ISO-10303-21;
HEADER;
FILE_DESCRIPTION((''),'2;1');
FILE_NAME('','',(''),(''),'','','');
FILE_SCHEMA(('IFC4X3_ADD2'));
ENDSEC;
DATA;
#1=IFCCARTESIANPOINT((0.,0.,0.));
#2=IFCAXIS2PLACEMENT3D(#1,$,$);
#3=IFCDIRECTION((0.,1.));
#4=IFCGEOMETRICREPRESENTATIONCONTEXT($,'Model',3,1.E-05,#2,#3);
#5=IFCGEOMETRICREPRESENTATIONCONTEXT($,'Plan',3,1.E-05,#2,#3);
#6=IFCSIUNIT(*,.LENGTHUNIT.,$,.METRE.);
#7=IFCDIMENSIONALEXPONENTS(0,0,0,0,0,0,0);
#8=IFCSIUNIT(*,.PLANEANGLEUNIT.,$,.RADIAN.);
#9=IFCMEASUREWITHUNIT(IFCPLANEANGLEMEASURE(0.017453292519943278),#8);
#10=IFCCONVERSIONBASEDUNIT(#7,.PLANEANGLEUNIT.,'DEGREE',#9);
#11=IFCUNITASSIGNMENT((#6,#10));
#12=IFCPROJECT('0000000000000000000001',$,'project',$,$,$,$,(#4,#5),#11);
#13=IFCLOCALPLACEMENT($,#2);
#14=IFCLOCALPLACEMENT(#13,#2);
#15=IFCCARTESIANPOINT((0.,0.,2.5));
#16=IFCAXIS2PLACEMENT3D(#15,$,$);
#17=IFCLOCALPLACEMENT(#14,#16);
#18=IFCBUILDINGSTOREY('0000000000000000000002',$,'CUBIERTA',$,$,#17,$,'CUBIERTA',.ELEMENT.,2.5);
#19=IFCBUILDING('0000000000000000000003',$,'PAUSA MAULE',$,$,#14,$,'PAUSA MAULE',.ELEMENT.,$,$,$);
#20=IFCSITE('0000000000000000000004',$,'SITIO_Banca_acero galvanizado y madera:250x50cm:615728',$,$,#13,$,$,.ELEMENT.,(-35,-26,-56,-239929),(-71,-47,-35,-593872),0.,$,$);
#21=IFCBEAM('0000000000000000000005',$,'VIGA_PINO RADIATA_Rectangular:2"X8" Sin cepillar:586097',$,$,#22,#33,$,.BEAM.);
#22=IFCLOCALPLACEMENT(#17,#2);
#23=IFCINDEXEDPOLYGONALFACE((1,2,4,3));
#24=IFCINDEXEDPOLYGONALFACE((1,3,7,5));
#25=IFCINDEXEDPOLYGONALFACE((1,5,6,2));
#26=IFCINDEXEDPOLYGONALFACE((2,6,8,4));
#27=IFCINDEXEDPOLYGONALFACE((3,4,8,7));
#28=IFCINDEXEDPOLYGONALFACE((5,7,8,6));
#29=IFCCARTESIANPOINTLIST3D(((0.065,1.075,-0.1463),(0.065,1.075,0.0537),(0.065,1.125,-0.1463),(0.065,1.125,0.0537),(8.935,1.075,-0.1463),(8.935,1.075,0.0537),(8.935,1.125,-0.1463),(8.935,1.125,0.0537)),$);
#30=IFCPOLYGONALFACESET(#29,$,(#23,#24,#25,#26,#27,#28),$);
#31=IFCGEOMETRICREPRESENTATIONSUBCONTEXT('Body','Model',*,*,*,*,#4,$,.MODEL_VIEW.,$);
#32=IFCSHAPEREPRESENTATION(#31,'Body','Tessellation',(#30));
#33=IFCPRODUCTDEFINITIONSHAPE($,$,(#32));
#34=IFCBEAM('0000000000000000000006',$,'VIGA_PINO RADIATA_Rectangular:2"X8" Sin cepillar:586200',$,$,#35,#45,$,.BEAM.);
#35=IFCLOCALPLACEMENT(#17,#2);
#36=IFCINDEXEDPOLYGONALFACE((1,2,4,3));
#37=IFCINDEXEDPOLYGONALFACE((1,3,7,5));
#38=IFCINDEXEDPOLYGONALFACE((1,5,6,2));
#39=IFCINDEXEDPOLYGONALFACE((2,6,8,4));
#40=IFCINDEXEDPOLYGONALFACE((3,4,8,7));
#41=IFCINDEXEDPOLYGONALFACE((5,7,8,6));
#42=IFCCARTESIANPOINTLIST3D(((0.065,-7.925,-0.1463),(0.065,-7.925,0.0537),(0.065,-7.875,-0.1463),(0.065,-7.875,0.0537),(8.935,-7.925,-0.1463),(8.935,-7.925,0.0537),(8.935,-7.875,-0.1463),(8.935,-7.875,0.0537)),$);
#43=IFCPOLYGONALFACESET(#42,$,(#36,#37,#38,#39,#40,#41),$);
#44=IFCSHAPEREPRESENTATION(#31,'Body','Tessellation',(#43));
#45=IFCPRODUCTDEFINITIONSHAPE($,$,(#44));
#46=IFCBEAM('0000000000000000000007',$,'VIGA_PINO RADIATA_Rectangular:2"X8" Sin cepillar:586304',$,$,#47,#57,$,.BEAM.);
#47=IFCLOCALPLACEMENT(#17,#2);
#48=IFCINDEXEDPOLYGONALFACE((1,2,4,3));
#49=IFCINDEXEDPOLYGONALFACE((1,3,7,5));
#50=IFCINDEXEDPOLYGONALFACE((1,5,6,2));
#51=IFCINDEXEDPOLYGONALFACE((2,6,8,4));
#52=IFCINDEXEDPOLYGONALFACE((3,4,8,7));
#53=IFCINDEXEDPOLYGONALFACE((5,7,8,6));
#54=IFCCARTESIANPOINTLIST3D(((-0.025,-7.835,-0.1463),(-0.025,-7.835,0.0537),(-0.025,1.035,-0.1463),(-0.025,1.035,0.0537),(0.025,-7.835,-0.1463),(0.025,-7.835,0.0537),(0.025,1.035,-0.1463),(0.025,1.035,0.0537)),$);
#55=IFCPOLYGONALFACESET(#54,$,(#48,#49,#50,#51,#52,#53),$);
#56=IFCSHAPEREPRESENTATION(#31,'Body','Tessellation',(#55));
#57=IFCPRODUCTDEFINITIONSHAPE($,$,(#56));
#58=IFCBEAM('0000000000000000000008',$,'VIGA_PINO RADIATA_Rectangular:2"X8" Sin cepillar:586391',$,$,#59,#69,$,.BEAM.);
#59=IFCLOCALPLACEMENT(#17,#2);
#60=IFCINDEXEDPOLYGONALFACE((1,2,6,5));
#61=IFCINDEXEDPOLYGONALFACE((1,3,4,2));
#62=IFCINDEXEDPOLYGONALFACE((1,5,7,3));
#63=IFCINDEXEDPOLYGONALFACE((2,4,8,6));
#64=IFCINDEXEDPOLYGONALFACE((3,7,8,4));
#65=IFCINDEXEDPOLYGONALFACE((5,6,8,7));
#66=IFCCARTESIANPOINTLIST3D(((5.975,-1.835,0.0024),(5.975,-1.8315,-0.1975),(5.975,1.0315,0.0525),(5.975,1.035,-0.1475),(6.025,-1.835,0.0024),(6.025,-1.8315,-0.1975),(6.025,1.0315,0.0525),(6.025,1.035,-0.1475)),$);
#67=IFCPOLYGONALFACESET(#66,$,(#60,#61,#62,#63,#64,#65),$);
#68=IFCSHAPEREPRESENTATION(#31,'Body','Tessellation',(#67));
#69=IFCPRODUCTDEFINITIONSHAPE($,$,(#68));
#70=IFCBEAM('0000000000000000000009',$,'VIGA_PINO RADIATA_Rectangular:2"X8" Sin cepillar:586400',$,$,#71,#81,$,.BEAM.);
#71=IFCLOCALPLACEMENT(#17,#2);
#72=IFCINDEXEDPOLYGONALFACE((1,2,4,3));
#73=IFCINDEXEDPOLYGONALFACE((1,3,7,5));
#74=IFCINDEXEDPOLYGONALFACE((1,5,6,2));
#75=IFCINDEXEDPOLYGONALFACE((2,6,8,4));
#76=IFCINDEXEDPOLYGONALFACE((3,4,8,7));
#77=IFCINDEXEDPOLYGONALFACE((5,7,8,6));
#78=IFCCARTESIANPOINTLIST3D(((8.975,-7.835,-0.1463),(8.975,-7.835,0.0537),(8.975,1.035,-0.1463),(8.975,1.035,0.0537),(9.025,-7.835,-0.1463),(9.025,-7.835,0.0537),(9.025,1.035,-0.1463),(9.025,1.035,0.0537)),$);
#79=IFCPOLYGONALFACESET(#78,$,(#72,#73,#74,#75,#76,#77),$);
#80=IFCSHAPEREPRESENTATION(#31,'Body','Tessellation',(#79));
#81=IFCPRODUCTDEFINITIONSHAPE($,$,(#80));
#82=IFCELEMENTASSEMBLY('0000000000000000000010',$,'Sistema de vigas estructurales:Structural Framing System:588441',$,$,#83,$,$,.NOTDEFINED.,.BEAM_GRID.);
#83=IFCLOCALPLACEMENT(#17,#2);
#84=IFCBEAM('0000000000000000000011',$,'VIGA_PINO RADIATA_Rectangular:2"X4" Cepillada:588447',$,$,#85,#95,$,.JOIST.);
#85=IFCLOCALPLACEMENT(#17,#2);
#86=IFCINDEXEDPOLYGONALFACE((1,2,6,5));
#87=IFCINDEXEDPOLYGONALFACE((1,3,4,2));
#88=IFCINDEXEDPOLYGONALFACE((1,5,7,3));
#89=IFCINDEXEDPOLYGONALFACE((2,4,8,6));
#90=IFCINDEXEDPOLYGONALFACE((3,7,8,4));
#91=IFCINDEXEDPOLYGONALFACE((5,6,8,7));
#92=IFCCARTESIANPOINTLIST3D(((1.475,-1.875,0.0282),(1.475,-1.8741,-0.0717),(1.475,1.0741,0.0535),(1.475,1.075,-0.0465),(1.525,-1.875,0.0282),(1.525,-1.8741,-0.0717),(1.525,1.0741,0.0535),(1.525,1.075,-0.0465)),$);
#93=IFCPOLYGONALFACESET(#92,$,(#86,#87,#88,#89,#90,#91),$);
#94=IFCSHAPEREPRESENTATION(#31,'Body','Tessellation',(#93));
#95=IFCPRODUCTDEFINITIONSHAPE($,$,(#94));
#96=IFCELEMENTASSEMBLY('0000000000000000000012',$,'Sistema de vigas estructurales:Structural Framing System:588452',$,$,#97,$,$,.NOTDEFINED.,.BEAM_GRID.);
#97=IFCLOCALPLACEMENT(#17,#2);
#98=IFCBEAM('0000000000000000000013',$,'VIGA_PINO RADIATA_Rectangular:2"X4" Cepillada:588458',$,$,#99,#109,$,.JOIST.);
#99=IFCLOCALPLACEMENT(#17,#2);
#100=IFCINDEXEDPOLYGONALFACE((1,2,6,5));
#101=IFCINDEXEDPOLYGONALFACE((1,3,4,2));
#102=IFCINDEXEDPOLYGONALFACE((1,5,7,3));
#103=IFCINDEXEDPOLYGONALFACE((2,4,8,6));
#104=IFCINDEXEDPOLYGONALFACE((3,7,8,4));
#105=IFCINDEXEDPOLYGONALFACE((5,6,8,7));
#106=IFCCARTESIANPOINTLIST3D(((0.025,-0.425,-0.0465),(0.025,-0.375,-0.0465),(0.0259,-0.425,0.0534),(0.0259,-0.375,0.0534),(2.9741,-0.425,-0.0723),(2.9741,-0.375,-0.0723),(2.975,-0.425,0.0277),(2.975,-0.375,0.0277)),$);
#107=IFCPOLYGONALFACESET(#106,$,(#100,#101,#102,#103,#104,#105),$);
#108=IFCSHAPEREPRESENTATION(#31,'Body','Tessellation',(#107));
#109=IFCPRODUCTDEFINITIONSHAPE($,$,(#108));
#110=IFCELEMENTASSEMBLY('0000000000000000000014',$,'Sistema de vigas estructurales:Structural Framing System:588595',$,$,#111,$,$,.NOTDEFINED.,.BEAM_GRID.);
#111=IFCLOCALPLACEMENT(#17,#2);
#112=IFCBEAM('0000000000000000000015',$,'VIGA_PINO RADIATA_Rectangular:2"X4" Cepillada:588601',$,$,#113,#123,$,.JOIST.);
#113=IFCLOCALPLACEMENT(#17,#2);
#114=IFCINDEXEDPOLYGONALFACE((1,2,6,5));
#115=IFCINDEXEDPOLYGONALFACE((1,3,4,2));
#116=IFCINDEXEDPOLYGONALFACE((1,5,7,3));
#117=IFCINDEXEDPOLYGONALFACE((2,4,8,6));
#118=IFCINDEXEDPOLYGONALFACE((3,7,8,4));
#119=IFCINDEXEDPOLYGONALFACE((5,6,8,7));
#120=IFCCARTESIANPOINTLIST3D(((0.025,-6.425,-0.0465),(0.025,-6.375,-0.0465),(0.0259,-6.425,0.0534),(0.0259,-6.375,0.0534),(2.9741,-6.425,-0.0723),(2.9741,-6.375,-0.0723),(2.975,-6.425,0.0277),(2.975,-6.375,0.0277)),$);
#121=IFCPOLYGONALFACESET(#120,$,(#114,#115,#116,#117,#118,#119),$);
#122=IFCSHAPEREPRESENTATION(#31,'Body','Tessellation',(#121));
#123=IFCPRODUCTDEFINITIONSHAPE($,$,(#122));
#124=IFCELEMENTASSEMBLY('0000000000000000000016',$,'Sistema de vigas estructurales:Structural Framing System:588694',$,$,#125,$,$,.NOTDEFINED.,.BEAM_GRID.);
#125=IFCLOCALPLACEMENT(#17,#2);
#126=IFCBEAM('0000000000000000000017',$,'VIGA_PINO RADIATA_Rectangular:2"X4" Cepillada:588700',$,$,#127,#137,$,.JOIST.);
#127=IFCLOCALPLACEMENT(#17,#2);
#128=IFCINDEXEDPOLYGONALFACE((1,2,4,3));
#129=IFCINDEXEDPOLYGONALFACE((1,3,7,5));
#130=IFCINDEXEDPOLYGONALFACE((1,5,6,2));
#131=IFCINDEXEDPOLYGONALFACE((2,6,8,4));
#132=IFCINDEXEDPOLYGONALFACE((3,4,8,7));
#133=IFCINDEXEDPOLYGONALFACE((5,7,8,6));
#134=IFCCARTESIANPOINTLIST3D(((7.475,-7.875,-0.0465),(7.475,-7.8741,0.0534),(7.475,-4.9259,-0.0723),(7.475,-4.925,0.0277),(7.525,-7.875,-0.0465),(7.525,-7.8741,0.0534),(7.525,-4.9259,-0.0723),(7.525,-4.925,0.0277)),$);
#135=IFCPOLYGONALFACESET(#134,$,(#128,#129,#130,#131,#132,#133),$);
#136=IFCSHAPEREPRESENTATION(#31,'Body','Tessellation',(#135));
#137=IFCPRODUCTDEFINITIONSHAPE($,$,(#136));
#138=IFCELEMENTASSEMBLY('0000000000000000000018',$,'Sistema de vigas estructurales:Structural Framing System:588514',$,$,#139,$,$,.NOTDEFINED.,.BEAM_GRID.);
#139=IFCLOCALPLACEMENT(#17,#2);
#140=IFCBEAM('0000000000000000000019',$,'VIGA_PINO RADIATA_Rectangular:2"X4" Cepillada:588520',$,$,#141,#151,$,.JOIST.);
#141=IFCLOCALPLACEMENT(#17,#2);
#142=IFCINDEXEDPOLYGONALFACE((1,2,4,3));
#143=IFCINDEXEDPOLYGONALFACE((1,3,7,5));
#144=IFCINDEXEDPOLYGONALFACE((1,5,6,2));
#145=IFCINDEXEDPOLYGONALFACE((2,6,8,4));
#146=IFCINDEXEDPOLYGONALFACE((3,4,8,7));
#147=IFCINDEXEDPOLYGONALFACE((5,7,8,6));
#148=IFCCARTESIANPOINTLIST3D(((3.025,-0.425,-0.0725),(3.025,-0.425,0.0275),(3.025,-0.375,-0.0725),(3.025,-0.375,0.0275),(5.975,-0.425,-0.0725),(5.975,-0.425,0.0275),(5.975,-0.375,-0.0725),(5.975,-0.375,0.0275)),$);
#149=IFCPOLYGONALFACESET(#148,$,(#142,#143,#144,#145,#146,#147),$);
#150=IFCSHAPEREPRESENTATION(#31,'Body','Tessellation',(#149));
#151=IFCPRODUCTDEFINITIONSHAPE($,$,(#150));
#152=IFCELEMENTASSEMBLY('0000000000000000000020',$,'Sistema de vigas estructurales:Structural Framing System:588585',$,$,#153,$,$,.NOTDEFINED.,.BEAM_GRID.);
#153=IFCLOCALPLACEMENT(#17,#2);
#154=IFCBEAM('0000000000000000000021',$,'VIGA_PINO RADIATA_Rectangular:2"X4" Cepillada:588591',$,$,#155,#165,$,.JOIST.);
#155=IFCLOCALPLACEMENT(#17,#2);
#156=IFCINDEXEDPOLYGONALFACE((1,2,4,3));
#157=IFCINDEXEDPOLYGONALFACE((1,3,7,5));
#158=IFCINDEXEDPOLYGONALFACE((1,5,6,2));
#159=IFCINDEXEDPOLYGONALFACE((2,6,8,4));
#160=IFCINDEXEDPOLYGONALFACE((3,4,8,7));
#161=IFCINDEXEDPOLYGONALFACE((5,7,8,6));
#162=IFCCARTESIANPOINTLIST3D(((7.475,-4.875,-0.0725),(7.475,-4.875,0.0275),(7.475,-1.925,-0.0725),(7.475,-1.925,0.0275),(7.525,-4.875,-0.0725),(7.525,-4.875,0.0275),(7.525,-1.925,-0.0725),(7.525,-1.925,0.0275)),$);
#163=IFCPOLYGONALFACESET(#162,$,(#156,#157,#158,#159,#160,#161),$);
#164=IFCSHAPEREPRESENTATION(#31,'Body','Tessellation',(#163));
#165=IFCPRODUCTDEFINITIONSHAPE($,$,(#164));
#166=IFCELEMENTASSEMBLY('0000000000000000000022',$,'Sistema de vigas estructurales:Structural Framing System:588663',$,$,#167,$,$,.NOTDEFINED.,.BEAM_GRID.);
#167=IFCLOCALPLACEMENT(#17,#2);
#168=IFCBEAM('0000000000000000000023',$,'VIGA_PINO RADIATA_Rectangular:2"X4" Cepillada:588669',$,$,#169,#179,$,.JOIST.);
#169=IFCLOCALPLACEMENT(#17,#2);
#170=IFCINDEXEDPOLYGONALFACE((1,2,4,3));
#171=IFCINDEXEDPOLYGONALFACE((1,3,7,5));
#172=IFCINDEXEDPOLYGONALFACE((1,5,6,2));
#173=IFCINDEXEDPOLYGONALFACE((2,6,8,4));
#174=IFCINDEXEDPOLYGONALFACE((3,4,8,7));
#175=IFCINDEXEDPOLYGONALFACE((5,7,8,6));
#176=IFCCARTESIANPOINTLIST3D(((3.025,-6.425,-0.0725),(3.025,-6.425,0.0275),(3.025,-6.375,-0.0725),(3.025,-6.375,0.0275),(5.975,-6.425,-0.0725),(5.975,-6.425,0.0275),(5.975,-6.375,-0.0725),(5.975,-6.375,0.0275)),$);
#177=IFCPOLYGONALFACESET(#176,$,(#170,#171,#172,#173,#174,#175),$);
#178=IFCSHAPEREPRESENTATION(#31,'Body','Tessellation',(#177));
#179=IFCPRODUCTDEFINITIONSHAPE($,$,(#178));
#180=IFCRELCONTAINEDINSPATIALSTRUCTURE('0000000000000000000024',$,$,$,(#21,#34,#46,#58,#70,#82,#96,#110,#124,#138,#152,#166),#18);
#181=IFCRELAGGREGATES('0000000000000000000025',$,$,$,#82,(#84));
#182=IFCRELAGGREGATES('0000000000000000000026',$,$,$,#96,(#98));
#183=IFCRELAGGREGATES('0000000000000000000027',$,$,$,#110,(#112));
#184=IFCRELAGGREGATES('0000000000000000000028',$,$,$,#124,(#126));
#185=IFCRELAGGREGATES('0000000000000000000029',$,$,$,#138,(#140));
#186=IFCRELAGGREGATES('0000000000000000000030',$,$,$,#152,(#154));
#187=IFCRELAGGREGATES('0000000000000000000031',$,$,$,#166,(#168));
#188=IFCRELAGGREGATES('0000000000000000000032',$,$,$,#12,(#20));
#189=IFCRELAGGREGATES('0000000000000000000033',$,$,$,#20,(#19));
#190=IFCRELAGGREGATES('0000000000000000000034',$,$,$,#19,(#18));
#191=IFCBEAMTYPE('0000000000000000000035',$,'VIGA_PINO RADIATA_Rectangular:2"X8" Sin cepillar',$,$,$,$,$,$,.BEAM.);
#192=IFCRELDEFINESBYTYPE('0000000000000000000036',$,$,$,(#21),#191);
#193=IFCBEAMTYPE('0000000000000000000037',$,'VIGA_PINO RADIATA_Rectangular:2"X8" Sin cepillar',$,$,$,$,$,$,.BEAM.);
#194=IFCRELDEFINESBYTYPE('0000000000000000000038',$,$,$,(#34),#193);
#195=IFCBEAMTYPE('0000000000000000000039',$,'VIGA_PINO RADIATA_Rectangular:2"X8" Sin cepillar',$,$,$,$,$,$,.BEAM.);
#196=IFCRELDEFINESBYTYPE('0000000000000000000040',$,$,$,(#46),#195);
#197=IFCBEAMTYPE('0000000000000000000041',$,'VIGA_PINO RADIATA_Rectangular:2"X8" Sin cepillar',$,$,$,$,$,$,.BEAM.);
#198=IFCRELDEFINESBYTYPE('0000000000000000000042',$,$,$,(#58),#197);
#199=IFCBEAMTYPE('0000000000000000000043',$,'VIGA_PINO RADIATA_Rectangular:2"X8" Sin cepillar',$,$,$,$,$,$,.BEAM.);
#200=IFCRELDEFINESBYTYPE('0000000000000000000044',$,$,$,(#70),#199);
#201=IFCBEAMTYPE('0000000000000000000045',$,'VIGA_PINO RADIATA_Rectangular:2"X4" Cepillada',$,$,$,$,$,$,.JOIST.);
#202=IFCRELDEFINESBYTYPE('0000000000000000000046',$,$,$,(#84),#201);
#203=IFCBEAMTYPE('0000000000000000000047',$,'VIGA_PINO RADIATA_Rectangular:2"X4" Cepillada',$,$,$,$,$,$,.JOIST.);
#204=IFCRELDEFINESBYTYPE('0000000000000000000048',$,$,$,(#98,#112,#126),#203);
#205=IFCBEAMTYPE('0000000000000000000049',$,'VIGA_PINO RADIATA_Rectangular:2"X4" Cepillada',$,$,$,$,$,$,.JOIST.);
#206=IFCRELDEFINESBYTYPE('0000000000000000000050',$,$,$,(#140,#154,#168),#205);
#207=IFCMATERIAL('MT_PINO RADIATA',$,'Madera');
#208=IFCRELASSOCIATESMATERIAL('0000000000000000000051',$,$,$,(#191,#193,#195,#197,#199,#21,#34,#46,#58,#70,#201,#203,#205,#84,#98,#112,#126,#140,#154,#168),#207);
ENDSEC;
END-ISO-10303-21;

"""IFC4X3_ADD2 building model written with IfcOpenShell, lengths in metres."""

from ifc_helpers import new_model, entity, si_unit, converted_unit, direction, frame, origin, origin_2d_with_axis, place, context, subcontext, project, spatial, rectangle, extrude, source, transform, mapped, material, material_profile, profile_set, profile_usage, type_object, type_shapes, element, aggregate, save


model = new_model("IFC4X3_ADD2")

# Units and contexts
model_context = context("Model", 3, precision=1e-05, world=origin(), true_north=direction((0.0, 1.0)))
plan_context = context("Plan", 3, precision=1e-05, world=origin(), true_north=direction((0.0, 1.0)))
body_context = subcontext(model_context, "Body", "Model", "MODEL_VIEW")
ifc_project = project(units=[si_unit("LENGTHUNIT", "METRE"), converted_unit("PLANEANGLEUNIT", "DEGREE", entity("IfcPlaneAngleMeasure", 0.017453292519943278), si_unit("PLANEANGLEUNIT", "RADIAN"), dimensions=[0, 0, 0, 0, 0, 0, 0])], contexts=[model_context, plan_context])

# Site, building, storey
site_placement = place(None, origin())
site = spatial("IfcSite", under=ifc_project, at=site_placement, Name="SITIO_Banca_acero galvanizado y madera:250x50cm:615728", CompositionType="ELEMENT", RefLatitude=(-35, -26, -56, -239929), RefLongitude=(-71, -47, -35, -593872), RefElevation=0.0)
building_placement = place(site_placement, origin())
building = spatial("IfcBuilding", under=site, at=building_placement, Name="PAUSA MAULE", LongName="PAUSA MAULE", CompositionType="ELEMENT")
storey_placement = place(building_placement, frame((0.0, 0.0, 2.5)))
storey = spatial("IfcBuildingStorey", under=building, at=storey_placement, Name="CUBIERTA", LongName="CUBIERTA", CompositionType="ELEMENT", Elevation=2.5)

# Beams
ifc_material_1 = material(Name="MT_PINO RADIATA", Category="Madera")
ifc_material_profile_1 = material_profile(ifc_material_1, rectangle(XDim=8.87, YDim=0.05, at=origin_2d_with_axis()), Name="2\"X8\" Sin cepillar")
ifc_profile_set_1 = profile_set([ifc_material_profile_1], Name="2\"X8\" Sin cepillar")
ifc_profile_usage_1 = profile_usage(ifc_profile_set_1, cardinal=8)
beam_type_1 = type_object("IfcBeamType", Name="VIGA_PINO RADIATA_Rectangular:2\"X8\" Sin cepillar", PredefinedType="BEAM", material=ifc_profile_set_1)
shared_shape_1 = source(origin(), body_context, "Body", "SweptSolid", [
    extrude(rectangle(XDim=8.87, YDim=0.05, at=origin_2d_with_axis()), frame((0.0, 0.0, -0.1), z_axis=(0.0, 0.0, 1.0), x_axis=(-1.0, 0.0, 0.0)), (0.0, 0.0, 1.0), 0.2),
])
type_shapes(beam_type_1, [shared_shape_1])
beam_1_placement = place(storey_placement, frame((4.5, 1.1, -0.0463)))
element("IfcBeam", 1, at=beam_1_placement, inside=storey, type_object=beam_type_1, material=ifc_profile_usage_1, Name="VIGA_PINO RADIATA_Rectangular:2\"X8\" Sin cepillar:586097", PredefinedType="BEAM", context=body_context, shape_type="MappedRepresentation", body=[
    mapped(shared_shape_1, transform((0.0, 0.0, 0.0), scale=1.0)),
])
beam_type_2 = type_object("IfcBeamType", Name="VIGA_PINO RADIATA_Rectangular:2\"X8\" Sin cepillar", PredefinedType="BEAM", material=ifc_profile_set_1)
shared_shape_2 = source(origin(), body_context, "Body", "SweptSolid", [
    extrude(rectangle(XDim=8.87, YDim=0.05, at=origin_2d_with_axis()), frame((-0.01, 0.0, -0.1), z_axis=(0.0, 0.0, 1.0), x_axis=(-1.0, 0.0, 0.0)), (0.0, 0.0, 1.0), 0.2),
])
type_shapes(beam_type_2, [shared_shape_2])
beam_2_placement = place(storey_placement, frame((4.51, -7.9, -0.0463)))
element("IfcBeam", 2, at=beam_2_placement, inside=storey, type_object=beam_type_2, material=ifc_profile_usage_1, Name="VIGA_PINO RADIATA_Rectangular:2\"X8\" Sin cepillar:586200", PredefinedType="BEAM", context=body_context, shape_type="MappedRepresentation", body=[
    mapped(shared_shape_2, transform((0.0, 0.0, 0.0), scale=1.0)),
])
beam_type_3 = type_object("IfcBeamType", Name="VIGA_PINO RADIATA_Rectangular:2\"X8\" Sin cepillar", PredefinedType="BEAM", material=ifc_profile_set_1)
shared_shape_3 = source(origin(), body_context, "Body", "SweptSolid", [
    extrude(rectangle(XDim=8.87, YDim=0.05, at=origin_2d_with_axis()), frame((-0.045, 0.0, -0.1), z_axis=(0.0, 0.0, 1.0), x_axis=(-1.0, 0.0, 0.0)), (0.0, 0.0, 1.0), 0.2),
])
type_shapes(beam_type_3, [shared_shape_3])
beam_3_placement = place(storey_placement, frame((0.0, -3.355, -0.0463), z_axis=(0.0, 0.0, 1.0), x_axis=(0.0, 1.0, 0.0)))
element("IfcBeam", 3, at=beam_3_placement, inside=storey, type_object=beam_type_3, material=ifc_profile_usage_1, Name="VIGA_PINO RADIATA_Rectangular:2\"X8\" Sin cepillar:586304", PredefinedType="BEAM", context=body_context, shape_type="MappedRepresentation", body=[
    mapped(shared_shape_3, transform((0.0, 0.0, 0.0), scale=1.0)),
])
beam_type_4 = type_object("IfcBeamType", Name="VIGA_PINO RADIATA_Rectangular:2\"X8\" Sin cepillar", PredefinedType="BEAM", material=ifc_profile_set_1)
shared_shape_4 = source(origin(), body_context, "Body", "SweptSolid", [
    extrude(rectangle(XDim=2.867, YDim=0.05, at=origin_2d_with_axis()), frame((-0.0018, 0.0, -0.1), z_axis=(0.0, 0.0, 1.0), x_axis=(-1.0, 0.0, 0.0)), (0.0, 0.0, 1.0), 0.2),
])
type_shapes(beam_type_4, [shared_shape_4])
beam_4_placement = place(storey_placement, frame((6.0, -0.3983, -0.0725), z_axis=(0.0, -0.017452, 0.999848), x_axis=(0.0, 0.999848, 0.017452)))
element("IfcBeam", 4, at=beam_4_placement, inside=storey, type_object=beam_type_4, material=ifc_profile_usage_1, Name="VIGA_PINO RADIATA_Rectangular:2\"X8\" Sin cepillar:586391", PredefinedType="BEAM", context=body_context, shape_type="MappedRepresentation", body=[
    mapped(shared_shape_4, transform((0.0, 0.0, 0.0), scale=1.0)),
])
beam_type_5 = type_object("IfcBeamType", Name="VIGA_PINO RADIATA_Rectangular:2\"X8\" Sin cepillar", PredefinedType="BEAM", material=ifc_profile_set_1)
shared_shape_5 = source(origin(), body_context, "Body", "SweptSolid", [
    extrude(rectangle(XDim=8.87, YDim=0.05, at=origin_2d_with_axis()), frame((-0.0325, 0.0, -0.1), z_axis=(0.0, 0.0, 1.0), x_axis=(-1.0, 0.0, 0.0)), (0.0, 0.0, 1.0), 0.2),
])
type_shapes(beam_type_5, [shared_shape_5])
beam_5_placement = place(storey_placement, frame((9.0, -3.3675, -0.0463), z_axis=(0.0, 0.0, 1.0), x_axis=(0.0, 1.0, 0.0)))
element("IfcBeam", 5, at=beam_5_placement, inside=storey, type_object=beam_type_5, material=ifc_profile_usage_1, Name="VIGA_PINO RADIATA_Rectangular:2\"X8\" Sin cepillar:586400", PredefinedType="BEAM", context=body_context, shape_type="MappedRepresentation", body=[
    mapped(shared_shape_5, transform((0.0, 0.0, 0.0), scale=1.0)),
])

# Element assemblies, beams
assembly_1_placement = place(storey_placement, origin())
assembly_1 = element("IfcElementAssembly", 6, at=assembly_1_placement, inside=storey, Name="Sistema de vigas estructurales:Structural Framing System:588441", AssemblyPlace="NOTDEFINED", PredefinedType="BEAM_GRID")
ifc_material_profile_2 = material_profile(ifc_material_1, rectangle(XDim=2.9493, YDim=0.05, at=origin_2d_with_axis()), Name="2\"X4\" Cepillada")
ifc_profile_set_2 = profile_set([ifc_material_profile_2], Name="2\"X4\" Cepillada")
ifc_profile_usage_2 = profile_usage(ifc_profile_set_2, cardinal=8)
beam_type_6 = type_object("IfcBeamType", Name="VIGA_PINO RADIATA_Rectangular:2\"X4\" Cepillada", PredefinedType="JOIST", material=ifc_profile_set_2)
shared_shape_6 = source(origin(), body_context, "Body", "SweptSolid", [
    extrude(rectangle(XDim=2.9493, YDim=0.05, at=origin_2d_with_axis()), frame((-0.0004, 0.0, -0.05), z_axis=(0.0, 0.0, 1.0), x_axis=(-1.0, 0.0, 0.0)), (0.0, 0.0, 1.0), 0.1),
])
type_shapes(beam_type_6, [shared_shape_6])
beam_6_placement = place(assembly_1_placement, frame((1.5, -0.3996, -0.0091), z_axis=(0.0, -0.008546, 0.999963), x_axis=(0.0, 0.999963, 0.008546)))
beam_6 = element("IfcBeam", 7, at=beam_6_placement, type_object=beam_type_6, material=ifc_profile_usage_2, Name="VIGA_PINO RADIATA_Rectangular:2\"X4\" Cepillada:588447", PredefinedType="JOIST", context=body_context, shape_type="MappedRepresentation", body=[
    mapped(shared_shape_6, transform((0.0, 0.0, 0.0), scale=1.0)),
])
aggregate(assembly_1, [beam_6])
assembly_2_placement = place(storey_placement, origin())
assembly_2 = element("IfcElementAssembly", 8, at=assembly_2_placement, inside=storey, Name="Sistema de vigas estructurales:Structural Framing System:588452", AssemblyPlace="NOTDEFINED", PredefinedType="BEAM_GRID")
beam_type_7 = type_object("IfcBeamType", Name="VIGA_PINO RADIATA_Rectangular:2\"X4\" Cepillada", PredefinedType="JOIST", material=ifc_profile_set_2)
shared_shape_7 = source(origin(), body_context, "Body", "SweptSolid", [
    extrude(rectangle(XDim=2.9492, YDim=0.05, at=origin_2d_with_axis()), frame((0.0004, 0.0, -0.05), z_axis=(0.0, 0.0, 1.0), x_axis=(-1.0, 0.0, 0.0)), (0.0, 0.0, 1.0), 0.1),
])
type_shapes(beam_type_7, [shared_shape_7])
beam_7_placement = place(assembly_2_placement, frame((1.4996, -0.4, -0.0094), z_axis=(0.008727, 0.0, 0.999962), x_axis=(0.999962, 0.0, -0.008727)))
beam_7 = element("IfcBeam", 9, at=beam_7_placement, type_object=beam_type_7, material=ifc_profile_usage_2, Name="VIGA_PINO RADIATA_Rectangular:2\"X4\" Cepillada:588458", PredefinedType="JOIST", context=body_context, shape_type="MappedRepresentation", body=[
    mapped(shared_shape_7, transform((0.0, 0.0, 0.0), scale=1.0)),
])
aggregate(assembly_2, [beam_7])
assembly_3_placement = place(storey_placement, origin())
assembly_3 = element("IfcElementAssembly", 10, at=assembly_3_placement, inside=storey, Name="Sistema de vigas estructurales:Structural Framing System:588595", AssemblyPlace="NOTDEFINED", PredefinedType="BEAM_GRID")
beam_8_placement = place(assembly_3_placement, frame((1.4996, -6.4, -0.0094), z_axis=(0.008727, 0.0, 0.999962), x_axis=(0.999962, 0.0, -0.008727)))
beam_8 = element("IfcBeam", 11, at=beam_8_placement, type_object=beam_type_7, material=ifc_profile_usage_2, Name="VIGA_PINO RADIATA_Rectangular:2\"X4\" Cepillada:588601", PredefinedType="JOIST", context=body_context, shape_type="MappedRepresentation", body=[
    mapped(shared_shape_7, transform((0.0, 0.0, 0.0), scale=1.0)),
])
aggregate(assembly_3, [beam_8])
assembly_4_placement = place(storey_placement, origin())
assembly_4 = element("IfcElementAssembly", 12, at=assembly_4_placement, inside=storey, Name="Sistema de vigas estructurales:Structural Framing System:588694", AssemblyPlace="NOTDEFINED", PredefinedType="BEAM_GRID")
beam_9_placement = place(assembly_4_placement, frame((7.5, -6.4004, -0.0094), z_axis=(0.0, 0.008727, 0.999962), x_axis=(0.0, 0.999962, -0.008727)))
beam_9 = element("IfcBeam", 13, at=beam_9_placement, type_object=beam_type_7, material=ifc_profile_usage_2, Name="VIGA_PINO RADIATA_Rectangular:2\"X4\" Cepillada:588700", PredefinedType="JOIST", context=body_context, shape_type="MappedRepresentation", body=[
    mapped(shared_shape_7, transform((0.0, 0.0, 0.0), scale=1.0)),
])
aggregate(assembly_4, [beam_9])
assembly_5_placement = place(storey_placement, origin())
assembly_5 = element("IfcElementAssembly", 14, at=assembly_5_placement, inside=storey, Name="Sistema de vigas estructurales:Structural Framing System:588514", AssemblyPlace="NOTDEFINED", PredefinedType="BEAM_GRID")
beam_type_8 = type_object("IfcBeamType", Name="VIGA_PINO RADIATA_Rectangular:2\"X4\" Cepillada", PredefinedType="JOIST", material=ifc_profile_set_2)
shared_shape_8 = source(origin(), body_context, "Body", "SweptSolid", [
    extrude(rectangle(XDim=2.95, YDim=0.05, at=origin_2d_with_axis()), frame((0.0, 0.0, -0.05), z_axis=(0.0, 0.0, 1.0), x_axis=(-1.0, 0.0, 0.0)), (0.0, 0.0, 1.0), 0.1),
])
type_shapes(beam_type_8, [shared_shape_8])
beam_10_placement = place(assembly_5_placement, frame((4.5, -0.4, -0.0225)))
beam_10 = element("IfcBeam", 15, at=beam_10_placement, type_object=beam_type_8, material=ifc_profile_usage_2, Name="VIGA_PINO RADIATA_Rectangular:2\"X4\" Cepillada:588520", PredefinedType="JOIST", context=body_context, shape_type="MappedRepresentation", body=[
    mapped(shared_shape_8, transform((0.0, 0.0, 0.0), scale=1.0)),
])
aggregate(assembly_5, [beam_10])
assembly_6_placement = place(storey_placement, origin())
assembly_6 = element("IfcElementAssembly", 16, at=assembly_6_placement, inside=storey, Name="Sistema de vigas estructurales:Structural Framing System:588585", AssemblyPlace="NOTDEFINED", PredefinedType="BEAM_GRID")
beam_11_placement = place(assembly_6_placement, frame((7.5, -3.4, -0.0225), z_axis=(0.0, 0.0, 1.0), x_axis=(0.0, 1.0, 0.0)))
beam_11 = element("IfcBeam", 17, at=beam_11_placement, type_object=beam_type_8, material=ifc_profile_usage_2, Name="VIGA_PINO RADIATA_Rectangular:2\"X4\" Cepillada:588591", PredefinedType="JOIST", context=body_context, shape_type="MappedRepresentation", body=[
    mapped(shared_shape_8, transform((0.0, 0.0, 0.0), scale=1.0)),
])
aggregate(assembly_6, [beam_11])
assembly_7_placement = place(storey_placement, origin())
assembly_7 = element("IfcElementAssembly", 18, at=assembly_7_placement, inside=storey, Name="Sistema de vigas estructurales:Structural Framing System:588663", AssemblyPlace="NOTDEFINED", PredefinedType="BEAM_GRID")
beam_12_placement = place(assembly_7_placement, frame((4.5, -6.4, -0.0225)))
beam_12 = element("IfcBeam", 19, at=beam_12_placement, type_object=beam_type_8, material=ifc_profile_usage_2, Name="VIGA_PINO RADIATA_Rectangular:2\"X4\" Cepillada:588669", PredefinedType="JOIST", context=body_context, shape_type="MappedRepresentation", body=[
    mapped(shared_shape_8, transform((0.0, 0.0, 0.0), scale=1.0)),
])
aggregate(assembly_7, [beam_12])

save(model, "model.ifc")
